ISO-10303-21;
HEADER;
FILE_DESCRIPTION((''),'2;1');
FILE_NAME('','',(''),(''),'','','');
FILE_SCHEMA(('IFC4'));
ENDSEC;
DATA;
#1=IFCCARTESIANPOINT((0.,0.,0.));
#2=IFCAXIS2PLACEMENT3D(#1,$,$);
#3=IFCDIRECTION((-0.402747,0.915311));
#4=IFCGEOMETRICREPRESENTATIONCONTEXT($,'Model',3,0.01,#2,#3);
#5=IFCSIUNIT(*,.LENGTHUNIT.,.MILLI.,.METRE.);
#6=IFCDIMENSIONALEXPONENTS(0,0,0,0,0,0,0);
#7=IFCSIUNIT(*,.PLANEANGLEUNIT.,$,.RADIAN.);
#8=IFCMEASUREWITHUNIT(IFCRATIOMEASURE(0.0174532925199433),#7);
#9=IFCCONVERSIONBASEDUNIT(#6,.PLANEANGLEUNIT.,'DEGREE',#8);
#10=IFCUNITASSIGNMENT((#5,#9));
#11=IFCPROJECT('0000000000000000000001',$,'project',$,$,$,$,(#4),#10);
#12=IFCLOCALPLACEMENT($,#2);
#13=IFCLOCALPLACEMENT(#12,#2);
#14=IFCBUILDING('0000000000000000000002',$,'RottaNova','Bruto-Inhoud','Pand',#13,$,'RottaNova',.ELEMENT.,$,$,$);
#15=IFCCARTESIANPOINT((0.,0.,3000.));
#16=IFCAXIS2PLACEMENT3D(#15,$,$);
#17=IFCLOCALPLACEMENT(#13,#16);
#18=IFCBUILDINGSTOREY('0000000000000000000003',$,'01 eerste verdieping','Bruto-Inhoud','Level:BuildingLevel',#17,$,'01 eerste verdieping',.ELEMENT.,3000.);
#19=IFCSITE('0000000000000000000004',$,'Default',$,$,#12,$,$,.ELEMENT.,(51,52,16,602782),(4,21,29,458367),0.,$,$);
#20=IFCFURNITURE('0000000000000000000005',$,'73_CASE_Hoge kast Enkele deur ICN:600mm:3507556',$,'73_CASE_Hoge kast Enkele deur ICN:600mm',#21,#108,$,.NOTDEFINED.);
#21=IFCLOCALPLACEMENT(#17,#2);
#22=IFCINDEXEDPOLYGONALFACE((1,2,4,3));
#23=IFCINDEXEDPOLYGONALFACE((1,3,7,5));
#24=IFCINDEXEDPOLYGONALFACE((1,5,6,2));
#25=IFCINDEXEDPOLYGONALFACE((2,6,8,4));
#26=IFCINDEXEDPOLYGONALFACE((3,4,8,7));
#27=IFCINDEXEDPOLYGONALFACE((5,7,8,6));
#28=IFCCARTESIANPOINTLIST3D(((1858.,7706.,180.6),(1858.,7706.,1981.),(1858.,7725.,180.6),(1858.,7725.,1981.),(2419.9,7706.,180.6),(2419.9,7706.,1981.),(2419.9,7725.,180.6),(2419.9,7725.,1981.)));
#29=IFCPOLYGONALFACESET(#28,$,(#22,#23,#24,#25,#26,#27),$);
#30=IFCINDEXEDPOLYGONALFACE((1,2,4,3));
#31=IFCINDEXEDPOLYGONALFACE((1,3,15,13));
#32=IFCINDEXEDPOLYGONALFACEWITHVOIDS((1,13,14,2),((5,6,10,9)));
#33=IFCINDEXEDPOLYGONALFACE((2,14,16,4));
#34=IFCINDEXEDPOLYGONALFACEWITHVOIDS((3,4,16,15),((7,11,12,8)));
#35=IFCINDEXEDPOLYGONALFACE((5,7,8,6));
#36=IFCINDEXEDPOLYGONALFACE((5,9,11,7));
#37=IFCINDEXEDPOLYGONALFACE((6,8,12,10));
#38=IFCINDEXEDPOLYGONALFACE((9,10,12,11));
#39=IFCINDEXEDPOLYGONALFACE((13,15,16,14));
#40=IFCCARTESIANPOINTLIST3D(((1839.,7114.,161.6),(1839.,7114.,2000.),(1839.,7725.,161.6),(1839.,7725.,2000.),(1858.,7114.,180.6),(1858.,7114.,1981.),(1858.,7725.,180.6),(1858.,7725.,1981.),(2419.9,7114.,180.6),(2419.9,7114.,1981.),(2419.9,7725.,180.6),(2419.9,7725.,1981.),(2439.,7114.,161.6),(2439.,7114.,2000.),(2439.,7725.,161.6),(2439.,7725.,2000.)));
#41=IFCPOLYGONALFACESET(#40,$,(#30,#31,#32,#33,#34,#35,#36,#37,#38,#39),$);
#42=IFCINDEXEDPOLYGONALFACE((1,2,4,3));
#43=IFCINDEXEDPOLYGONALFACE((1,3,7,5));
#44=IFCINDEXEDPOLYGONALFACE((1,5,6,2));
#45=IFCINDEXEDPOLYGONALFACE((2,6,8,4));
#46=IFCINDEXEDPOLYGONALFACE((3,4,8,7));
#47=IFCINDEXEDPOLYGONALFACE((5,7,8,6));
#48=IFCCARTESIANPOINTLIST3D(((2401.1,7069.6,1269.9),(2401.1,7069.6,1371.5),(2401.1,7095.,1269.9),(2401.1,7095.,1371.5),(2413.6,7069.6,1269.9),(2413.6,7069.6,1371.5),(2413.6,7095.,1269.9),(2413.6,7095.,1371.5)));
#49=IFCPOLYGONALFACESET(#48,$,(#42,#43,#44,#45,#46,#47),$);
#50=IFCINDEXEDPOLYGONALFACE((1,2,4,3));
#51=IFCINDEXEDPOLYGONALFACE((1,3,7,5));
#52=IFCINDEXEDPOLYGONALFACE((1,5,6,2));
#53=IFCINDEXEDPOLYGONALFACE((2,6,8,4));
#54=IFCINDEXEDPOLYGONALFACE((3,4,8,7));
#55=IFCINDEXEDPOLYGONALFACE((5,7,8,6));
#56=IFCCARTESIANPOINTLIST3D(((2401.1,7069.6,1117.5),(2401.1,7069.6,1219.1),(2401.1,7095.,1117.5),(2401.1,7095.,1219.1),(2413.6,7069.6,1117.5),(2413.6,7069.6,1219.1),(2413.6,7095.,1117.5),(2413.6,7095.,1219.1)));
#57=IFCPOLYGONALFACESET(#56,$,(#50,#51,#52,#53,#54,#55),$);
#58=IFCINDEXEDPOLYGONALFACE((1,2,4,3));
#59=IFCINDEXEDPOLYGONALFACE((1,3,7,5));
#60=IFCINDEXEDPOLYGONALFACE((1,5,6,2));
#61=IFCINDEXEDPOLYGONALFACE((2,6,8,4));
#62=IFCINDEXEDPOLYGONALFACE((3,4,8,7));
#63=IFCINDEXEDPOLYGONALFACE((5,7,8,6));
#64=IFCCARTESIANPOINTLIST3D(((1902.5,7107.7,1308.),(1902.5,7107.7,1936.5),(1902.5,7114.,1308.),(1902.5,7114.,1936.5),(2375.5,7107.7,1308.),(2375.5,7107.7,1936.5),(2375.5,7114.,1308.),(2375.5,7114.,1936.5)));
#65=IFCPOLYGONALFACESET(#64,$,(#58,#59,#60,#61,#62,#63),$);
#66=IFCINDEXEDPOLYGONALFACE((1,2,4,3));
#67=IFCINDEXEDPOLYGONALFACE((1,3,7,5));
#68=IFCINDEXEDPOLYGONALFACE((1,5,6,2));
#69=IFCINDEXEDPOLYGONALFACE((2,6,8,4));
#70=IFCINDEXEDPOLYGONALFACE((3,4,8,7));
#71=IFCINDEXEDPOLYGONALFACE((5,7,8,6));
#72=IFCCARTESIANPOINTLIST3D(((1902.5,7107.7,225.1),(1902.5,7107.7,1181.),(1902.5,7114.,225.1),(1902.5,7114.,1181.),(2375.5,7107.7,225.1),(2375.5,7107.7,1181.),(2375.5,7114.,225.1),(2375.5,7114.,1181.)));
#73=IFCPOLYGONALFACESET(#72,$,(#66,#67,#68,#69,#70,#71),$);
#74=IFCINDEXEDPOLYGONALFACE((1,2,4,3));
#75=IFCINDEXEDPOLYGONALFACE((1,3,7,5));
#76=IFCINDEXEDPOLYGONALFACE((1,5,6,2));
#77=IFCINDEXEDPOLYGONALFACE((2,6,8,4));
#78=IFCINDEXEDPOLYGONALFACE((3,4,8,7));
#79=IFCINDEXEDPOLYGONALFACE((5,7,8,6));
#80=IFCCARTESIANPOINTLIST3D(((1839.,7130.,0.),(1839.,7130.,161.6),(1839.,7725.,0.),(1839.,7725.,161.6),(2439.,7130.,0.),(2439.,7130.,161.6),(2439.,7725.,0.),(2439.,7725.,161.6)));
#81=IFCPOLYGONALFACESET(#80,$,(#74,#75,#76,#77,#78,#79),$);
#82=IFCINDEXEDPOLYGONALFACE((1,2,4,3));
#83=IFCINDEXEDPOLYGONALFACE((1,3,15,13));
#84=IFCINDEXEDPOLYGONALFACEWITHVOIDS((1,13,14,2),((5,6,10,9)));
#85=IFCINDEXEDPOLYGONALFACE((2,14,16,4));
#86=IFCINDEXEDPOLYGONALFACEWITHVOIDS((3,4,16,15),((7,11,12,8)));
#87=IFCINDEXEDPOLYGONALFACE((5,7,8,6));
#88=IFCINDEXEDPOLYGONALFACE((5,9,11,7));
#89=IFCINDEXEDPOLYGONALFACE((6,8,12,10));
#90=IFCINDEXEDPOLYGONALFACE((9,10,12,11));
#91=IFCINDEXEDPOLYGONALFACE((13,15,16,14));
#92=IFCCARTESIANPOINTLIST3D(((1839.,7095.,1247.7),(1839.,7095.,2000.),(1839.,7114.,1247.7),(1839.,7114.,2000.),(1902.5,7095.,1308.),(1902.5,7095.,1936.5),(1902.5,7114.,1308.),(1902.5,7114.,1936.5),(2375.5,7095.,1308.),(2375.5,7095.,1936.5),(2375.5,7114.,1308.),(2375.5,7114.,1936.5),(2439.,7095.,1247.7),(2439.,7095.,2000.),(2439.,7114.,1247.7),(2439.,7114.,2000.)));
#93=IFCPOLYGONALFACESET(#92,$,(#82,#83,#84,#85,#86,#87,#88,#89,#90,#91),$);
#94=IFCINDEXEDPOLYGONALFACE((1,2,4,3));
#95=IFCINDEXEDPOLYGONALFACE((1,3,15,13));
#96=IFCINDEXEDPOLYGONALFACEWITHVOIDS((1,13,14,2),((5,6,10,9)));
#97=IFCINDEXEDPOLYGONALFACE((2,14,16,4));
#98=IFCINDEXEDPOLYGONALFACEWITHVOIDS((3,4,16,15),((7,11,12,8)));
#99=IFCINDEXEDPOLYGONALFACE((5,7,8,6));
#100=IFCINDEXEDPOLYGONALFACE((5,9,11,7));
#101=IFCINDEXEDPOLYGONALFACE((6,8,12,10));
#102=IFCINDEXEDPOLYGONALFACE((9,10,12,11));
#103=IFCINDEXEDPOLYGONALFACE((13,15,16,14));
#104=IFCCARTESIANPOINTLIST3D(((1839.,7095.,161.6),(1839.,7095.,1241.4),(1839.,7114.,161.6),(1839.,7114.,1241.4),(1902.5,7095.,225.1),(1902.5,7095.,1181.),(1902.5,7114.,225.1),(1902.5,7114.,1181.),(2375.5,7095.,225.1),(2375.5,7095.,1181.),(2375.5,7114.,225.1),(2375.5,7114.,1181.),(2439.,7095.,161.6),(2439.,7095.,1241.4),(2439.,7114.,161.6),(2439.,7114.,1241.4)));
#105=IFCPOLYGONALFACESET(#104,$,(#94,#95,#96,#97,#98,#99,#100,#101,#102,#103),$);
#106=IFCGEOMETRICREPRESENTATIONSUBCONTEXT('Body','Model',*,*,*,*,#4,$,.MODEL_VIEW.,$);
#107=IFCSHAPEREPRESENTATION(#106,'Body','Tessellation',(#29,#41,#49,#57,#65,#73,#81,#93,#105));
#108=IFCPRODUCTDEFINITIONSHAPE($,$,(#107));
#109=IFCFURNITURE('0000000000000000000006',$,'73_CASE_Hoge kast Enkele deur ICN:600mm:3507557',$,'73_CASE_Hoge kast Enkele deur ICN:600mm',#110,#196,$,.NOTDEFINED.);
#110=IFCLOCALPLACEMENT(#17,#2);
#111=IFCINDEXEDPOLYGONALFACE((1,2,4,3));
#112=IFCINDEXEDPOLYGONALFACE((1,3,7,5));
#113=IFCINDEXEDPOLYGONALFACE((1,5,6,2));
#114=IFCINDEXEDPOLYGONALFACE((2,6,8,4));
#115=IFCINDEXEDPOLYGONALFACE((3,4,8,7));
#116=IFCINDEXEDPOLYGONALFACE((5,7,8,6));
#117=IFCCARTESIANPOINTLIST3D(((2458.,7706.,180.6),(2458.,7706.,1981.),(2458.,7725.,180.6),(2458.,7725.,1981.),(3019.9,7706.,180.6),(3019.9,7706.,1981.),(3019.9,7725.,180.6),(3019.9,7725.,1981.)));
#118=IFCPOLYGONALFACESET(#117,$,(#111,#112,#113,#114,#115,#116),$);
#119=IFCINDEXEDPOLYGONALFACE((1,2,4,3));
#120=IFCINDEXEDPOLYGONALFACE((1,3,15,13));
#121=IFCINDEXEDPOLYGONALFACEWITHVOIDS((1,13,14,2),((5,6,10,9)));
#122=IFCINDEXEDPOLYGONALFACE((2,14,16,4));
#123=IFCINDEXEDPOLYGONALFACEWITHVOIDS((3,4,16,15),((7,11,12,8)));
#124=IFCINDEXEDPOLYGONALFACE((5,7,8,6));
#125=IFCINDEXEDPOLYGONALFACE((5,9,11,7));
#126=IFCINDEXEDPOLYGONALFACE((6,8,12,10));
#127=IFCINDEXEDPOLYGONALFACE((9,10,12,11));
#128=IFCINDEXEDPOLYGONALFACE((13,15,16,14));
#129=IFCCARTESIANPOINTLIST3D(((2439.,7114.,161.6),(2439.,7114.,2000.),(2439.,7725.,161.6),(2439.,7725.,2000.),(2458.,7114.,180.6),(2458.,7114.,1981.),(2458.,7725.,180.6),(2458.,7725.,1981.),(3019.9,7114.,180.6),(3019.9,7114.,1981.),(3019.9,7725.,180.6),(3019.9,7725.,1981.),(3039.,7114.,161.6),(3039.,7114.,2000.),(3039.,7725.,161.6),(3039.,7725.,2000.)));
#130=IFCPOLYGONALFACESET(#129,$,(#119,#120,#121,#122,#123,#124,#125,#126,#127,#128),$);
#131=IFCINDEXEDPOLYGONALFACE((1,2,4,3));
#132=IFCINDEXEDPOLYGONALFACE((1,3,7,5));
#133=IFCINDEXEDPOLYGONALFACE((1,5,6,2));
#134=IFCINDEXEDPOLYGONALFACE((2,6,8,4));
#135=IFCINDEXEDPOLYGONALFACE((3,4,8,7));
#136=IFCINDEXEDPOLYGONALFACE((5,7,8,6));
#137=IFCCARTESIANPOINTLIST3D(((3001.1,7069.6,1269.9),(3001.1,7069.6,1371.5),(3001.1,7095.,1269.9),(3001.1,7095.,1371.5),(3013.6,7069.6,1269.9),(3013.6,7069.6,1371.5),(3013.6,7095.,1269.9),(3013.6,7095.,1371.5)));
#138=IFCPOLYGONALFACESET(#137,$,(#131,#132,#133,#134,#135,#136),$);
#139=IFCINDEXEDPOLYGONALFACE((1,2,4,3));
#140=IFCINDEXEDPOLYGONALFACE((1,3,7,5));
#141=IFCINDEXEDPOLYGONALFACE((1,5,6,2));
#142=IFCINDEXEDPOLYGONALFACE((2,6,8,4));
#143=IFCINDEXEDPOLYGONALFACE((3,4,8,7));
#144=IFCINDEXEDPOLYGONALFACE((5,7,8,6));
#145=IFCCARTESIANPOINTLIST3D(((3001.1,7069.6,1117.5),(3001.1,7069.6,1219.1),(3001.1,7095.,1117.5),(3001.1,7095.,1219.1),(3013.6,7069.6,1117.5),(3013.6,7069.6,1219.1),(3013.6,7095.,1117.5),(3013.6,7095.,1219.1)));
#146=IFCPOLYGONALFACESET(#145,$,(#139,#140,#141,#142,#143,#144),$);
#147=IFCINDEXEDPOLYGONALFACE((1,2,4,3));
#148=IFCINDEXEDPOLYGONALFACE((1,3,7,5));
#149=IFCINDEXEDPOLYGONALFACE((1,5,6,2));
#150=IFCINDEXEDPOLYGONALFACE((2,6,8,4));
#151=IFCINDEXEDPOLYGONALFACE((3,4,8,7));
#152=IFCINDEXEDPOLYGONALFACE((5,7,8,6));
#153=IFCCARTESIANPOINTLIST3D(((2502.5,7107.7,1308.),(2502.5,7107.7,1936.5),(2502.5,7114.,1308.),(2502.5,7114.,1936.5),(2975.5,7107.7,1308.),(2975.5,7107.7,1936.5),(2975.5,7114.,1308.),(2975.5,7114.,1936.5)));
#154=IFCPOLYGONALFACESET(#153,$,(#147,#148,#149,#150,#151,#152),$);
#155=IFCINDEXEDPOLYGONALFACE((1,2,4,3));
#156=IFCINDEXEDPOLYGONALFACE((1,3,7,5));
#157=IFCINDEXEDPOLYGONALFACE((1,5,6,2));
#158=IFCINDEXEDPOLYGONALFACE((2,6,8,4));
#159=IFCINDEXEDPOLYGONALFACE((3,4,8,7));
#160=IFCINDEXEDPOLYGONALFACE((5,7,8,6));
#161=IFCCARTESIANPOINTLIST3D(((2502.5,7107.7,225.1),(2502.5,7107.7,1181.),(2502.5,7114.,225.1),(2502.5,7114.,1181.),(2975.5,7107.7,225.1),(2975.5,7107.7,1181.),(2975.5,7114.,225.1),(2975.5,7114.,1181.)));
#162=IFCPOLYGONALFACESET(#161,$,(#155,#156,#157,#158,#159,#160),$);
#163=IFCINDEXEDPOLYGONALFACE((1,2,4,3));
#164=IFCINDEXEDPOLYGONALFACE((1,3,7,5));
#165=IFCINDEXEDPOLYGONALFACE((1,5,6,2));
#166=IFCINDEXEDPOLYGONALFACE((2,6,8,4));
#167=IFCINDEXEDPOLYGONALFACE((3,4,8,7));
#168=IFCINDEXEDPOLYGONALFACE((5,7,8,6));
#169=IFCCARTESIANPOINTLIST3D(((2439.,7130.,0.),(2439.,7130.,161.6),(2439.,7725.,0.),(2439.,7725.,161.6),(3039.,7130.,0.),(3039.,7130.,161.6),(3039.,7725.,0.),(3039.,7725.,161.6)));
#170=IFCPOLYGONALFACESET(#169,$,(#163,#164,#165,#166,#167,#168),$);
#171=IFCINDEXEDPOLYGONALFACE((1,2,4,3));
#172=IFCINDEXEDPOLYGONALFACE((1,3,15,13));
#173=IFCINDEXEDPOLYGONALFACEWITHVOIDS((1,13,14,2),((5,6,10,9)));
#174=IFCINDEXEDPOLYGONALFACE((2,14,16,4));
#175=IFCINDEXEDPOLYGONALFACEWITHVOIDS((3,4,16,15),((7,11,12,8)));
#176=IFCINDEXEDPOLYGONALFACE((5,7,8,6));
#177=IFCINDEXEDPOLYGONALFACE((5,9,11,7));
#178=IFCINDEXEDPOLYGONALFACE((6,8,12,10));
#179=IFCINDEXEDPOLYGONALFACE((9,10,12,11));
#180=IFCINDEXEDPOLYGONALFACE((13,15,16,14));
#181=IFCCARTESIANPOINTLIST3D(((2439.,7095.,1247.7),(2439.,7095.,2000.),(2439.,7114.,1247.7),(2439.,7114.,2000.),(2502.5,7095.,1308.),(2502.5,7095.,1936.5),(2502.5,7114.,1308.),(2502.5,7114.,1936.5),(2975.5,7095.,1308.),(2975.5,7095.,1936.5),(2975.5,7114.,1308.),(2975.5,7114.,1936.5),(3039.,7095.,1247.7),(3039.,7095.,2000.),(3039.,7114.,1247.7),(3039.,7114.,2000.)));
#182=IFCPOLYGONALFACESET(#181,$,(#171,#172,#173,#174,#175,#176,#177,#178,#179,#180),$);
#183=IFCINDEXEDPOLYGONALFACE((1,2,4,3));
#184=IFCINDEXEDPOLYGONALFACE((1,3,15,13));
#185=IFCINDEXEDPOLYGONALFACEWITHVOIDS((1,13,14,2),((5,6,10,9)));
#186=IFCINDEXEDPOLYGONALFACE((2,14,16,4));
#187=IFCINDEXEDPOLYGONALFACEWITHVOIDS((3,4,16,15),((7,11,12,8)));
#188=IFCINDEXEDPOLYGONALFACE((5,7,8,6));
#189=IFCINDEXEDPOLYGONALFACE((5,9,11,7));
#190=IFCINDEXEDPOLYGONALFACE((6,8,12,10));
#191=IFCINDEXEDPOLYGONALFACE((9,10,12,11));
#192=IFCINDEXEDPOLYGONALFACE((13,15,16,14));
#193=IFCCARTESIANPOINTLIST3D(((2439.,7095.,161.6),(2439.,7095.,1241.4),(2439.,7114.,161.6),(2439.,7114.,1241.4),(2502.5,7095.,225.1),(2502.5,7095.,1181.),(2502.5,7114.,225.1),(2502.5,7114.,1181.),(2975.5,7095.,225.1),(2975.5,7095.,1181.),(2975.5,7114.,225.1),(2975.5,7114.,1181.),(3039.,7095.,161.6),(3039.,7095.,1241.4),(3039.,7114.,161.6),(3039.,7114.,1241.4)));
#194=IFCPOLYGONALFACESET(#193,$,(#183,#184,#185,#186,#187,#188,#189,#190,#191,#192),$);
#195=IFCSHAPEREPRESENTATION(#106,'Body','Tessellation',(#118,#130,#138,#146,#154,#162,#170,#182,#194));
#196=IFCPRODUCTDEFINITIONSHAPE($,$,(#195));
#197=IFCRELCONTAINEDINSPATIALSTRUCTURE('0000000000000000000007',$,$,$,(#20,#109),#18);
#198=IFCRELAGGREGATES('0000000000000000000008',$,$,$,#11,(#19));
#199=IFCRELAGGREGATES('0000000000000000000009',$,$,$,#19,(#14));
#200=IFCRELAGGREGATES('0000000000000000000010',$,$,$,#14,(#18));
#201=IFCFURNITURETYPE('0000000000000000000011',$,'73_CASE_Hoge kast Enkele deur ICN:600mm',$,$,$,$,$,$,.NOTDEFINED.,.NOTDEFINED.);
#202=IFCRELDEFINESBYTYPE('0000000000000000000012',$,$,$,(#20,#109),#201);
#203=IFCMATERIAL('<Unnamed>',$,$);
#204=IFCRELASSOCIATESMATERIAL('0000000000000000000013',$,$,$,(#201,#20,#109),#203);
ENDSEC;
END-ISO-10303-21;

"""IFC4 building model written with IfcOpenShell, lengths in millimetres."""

from ifc_helpers import new_model, entity, si_unit, converted_unit, direction, frame, frame_2d, origin, origin_2d_with_axis, place, context, subcontext, project, spatial, polyline, rectangle, outline, extrude, source, transform, mapped, material, type_object, type_shapes, element, save


model = new_model("IFC4")

# Units and contexts
model_context = context("Model", 3, precision=0.01, world=origin(), true_north=direction((-0.402747, 0.915311)))
body_context = subcontext(model_context, "Body", "Model", "MODEL_VIEW")
ifc_project = project(units=[si_unit("LENGTHUNIT", "METRE", prefix="MILLI"), converted_unit("PLANEANGLEUNIT", "DEGREE", entity("IfcRatioMeasure", 0.0174532925199433), si_unit("PLANEANGLEUNIT", "RADIAN"), dimensions=[0, 0, 0, 0, 0, 0, 0])], contexts=[model_context])

# Site, building, storey
site_placement = place(None, origin())
site = spatial("IfcSite", under=ifc_project, at=site_placement, Name="Default", CompositionType="ELEMENT", RefLatitude=(51, 52, 16, 602782), RefLongitude=(4, 21, 29, 458367), RefElevation=0.0)
building_placement = place(site_placement, origin())
building = spatial("IfcBuilding", under=site, at=building_placement, Name="RottaNova", Description="Bruto-Inhoud", ObjectType="Pand", LongName="RottaNova", CompositionType="ELEMENT")
storey_placement = place(building_placement, frame((0.0, 0.0, 3000.0)))
storey = spatial("IfcBuildingStorey", under=building, at=storey_placement, Name="01 eerste verdieping", Description="Bruto-Inhoud", ObjectType="Level:BuildingLevel", LongName="01 eerste verdieping", CompositionType="ELEMENT", Elevation=3000.0)

# Furniture
ifc_material_1 = material(Name="<Unnamed>")
furniture_type = type_object("IfcFurnitureType", Name="73_CASE_Hoge kast Enkele deur ICN:600mm", AssemblyPlace="NOTDEFINED", PredefinedType="NOTDEFINED", material=ifc_material_1)
shared_shape_1 = source(origin(), body_context, "Body", "SweptSolid", [
    extrude(rectangle(XDim=19.1, YDim=561.9, at=origin_2d_with_axis()), frame((18.7, -9.5, 180.6), z_axis=(0.0, 0.0, 1.0), x_axis=(0.0, 1.0, 0.0)), (0.0, 0.0, 1.0), 1800.3),
    extrude(outline(polyline([(-300.0, -919.2), (300.0, -919.2), (300.0, 919.2), (-300.0, 919.2), (-300.0, -919.2)]), holes=[polyline([(-280.9, 900.2), (281.0, 900.2), (281.0, -900.2), (-280.9, -900.2), (-280.9, 900.2)])]), frame((18.7, -611.0, 1080.8), z_axis=(0.0, 1.0, 0.0), x_axis=(-1.0, 0.0, 0.0)), (0.0, 0.0, 1.0), 610.9),
    extrude(rectangle(XDim=25.4, YDim=12.5, at=frame_2d((0.0, 0.0), x_axis=(1.0, 0.0))), frame((287.1, -642.7, 1269.9), z_axis=(0.0, 0.0, 1.0), x_axis=(0.0, 1.0, 0.0)), (0.0, 0.0, 1.0), 101.6),
    extrude(rectangle(XDim=25.4, YDim=12.5, at=frame_2d((0.0, 0.0), x_axis=(1.0, 0.0))), frame((287.1, -642.7, 1117.5), z_axis=(0.0, 0.0, 1.0), x_axis=(0.0, 1.0, 0.0)), (0.0, 0.0, 1.0), 101.6),
    extrude(rectangle(XDim=6.4, YDim=473.0, at=frame_2d((0.0, 0.0), x_axis=(1.0, 0.0))), frame((18.7, -614.1, 1308.0), z_axis=(0.0, 0.0, 1.0), x_axis=(0.0, 1.0, 0.0)), (0.0, 0.0, 1.0), 628.5),
    extrude(rectangle(XDim=6.4, YDim=473.0, at=origin_2d_with_axis()), frame((18.7, -614.1, 225.1), z_axis=(0.0, 0.0, 1.0), x_axis=(0.0, 1.0, 0.0)), (0.0, 0.0, 1.0), 956.0),
    extrude(rectangle(XDim=600.0, YDim=595.0, at=frame_2d((0.0, 0.0), x_axis=(1.0, 0.0))), frame((18.7, -297.5, 0.0), z_axis=(0.0, 0.0, 1.0), x_axis=(-1.0, 0.0, 0.0)), (0.0, 0.0, 1.0), 161.6),
    extrude(outline(polyline([(-376.1, -300.0), (376.1, -300.0), (376.1, 300.0), (-376.1, 300.0), (-376.1, -300.0)]), holes=[polyline([(-312.6, -236.5), (-312.6, 236.5), (315.8, 236.5), (315.8, -236.5), (-312.6, -236.5)])]), frame((18.7, -630.0, 1623.9), z_axis=(0.0, 1.0, 0.0), x_axis=(0.0, 0.0, -1.0)), (0.0, 0.0, 1.0), 19.1),
    extrude(outline(polyline([(-300.0, -539.9), (300.0, -539.9), (300.0, 539.9), (-300.0, 539.9), (-300.0, -539.9)]), holes=[polyline([(-236.5, 479.6), (236.5, 479.6), (236.5, -476.4), (-236.5, -476.4), (-236.5, 479.6)])]), frame((18.7, -630.0, 701.5), z_axis=(0.0, 1.0, 0.0), x_axis=(-1.0, 0.0, 0.0)), (0.0, 0.0, 1.0), 19.1),
])
type_shapes(furniture_type, [shared_shape_1])
for number, where, name in (
    (1, (2120.3, 7725.0, 0.0), "73_CASE_Hoge kast Enkele deur ICN:600mm:3507556"),
    (2, (2720.3, 7725.0, 0.0), "73_CASE_Hoge kast Enkele deur ICN:600mm:3507557"),
):
    element("IfcFurniture", number, at=place(storey_placement, frame(where)), inside=storey, type_object=furniture_type, material=ifc_material_1, Name=name, ObjectType="73_CASE_Hoge kast Enkele deur ICN:600mm", PredefinedType="NOTDEFINED", context=body_context, shape_type="MappedRepresentation", body=[
        mapped(shared_shape_1, transform((0.0, 0.0, 0.0), scale=1.0)),
    ])

save(model, "model.ifc")
